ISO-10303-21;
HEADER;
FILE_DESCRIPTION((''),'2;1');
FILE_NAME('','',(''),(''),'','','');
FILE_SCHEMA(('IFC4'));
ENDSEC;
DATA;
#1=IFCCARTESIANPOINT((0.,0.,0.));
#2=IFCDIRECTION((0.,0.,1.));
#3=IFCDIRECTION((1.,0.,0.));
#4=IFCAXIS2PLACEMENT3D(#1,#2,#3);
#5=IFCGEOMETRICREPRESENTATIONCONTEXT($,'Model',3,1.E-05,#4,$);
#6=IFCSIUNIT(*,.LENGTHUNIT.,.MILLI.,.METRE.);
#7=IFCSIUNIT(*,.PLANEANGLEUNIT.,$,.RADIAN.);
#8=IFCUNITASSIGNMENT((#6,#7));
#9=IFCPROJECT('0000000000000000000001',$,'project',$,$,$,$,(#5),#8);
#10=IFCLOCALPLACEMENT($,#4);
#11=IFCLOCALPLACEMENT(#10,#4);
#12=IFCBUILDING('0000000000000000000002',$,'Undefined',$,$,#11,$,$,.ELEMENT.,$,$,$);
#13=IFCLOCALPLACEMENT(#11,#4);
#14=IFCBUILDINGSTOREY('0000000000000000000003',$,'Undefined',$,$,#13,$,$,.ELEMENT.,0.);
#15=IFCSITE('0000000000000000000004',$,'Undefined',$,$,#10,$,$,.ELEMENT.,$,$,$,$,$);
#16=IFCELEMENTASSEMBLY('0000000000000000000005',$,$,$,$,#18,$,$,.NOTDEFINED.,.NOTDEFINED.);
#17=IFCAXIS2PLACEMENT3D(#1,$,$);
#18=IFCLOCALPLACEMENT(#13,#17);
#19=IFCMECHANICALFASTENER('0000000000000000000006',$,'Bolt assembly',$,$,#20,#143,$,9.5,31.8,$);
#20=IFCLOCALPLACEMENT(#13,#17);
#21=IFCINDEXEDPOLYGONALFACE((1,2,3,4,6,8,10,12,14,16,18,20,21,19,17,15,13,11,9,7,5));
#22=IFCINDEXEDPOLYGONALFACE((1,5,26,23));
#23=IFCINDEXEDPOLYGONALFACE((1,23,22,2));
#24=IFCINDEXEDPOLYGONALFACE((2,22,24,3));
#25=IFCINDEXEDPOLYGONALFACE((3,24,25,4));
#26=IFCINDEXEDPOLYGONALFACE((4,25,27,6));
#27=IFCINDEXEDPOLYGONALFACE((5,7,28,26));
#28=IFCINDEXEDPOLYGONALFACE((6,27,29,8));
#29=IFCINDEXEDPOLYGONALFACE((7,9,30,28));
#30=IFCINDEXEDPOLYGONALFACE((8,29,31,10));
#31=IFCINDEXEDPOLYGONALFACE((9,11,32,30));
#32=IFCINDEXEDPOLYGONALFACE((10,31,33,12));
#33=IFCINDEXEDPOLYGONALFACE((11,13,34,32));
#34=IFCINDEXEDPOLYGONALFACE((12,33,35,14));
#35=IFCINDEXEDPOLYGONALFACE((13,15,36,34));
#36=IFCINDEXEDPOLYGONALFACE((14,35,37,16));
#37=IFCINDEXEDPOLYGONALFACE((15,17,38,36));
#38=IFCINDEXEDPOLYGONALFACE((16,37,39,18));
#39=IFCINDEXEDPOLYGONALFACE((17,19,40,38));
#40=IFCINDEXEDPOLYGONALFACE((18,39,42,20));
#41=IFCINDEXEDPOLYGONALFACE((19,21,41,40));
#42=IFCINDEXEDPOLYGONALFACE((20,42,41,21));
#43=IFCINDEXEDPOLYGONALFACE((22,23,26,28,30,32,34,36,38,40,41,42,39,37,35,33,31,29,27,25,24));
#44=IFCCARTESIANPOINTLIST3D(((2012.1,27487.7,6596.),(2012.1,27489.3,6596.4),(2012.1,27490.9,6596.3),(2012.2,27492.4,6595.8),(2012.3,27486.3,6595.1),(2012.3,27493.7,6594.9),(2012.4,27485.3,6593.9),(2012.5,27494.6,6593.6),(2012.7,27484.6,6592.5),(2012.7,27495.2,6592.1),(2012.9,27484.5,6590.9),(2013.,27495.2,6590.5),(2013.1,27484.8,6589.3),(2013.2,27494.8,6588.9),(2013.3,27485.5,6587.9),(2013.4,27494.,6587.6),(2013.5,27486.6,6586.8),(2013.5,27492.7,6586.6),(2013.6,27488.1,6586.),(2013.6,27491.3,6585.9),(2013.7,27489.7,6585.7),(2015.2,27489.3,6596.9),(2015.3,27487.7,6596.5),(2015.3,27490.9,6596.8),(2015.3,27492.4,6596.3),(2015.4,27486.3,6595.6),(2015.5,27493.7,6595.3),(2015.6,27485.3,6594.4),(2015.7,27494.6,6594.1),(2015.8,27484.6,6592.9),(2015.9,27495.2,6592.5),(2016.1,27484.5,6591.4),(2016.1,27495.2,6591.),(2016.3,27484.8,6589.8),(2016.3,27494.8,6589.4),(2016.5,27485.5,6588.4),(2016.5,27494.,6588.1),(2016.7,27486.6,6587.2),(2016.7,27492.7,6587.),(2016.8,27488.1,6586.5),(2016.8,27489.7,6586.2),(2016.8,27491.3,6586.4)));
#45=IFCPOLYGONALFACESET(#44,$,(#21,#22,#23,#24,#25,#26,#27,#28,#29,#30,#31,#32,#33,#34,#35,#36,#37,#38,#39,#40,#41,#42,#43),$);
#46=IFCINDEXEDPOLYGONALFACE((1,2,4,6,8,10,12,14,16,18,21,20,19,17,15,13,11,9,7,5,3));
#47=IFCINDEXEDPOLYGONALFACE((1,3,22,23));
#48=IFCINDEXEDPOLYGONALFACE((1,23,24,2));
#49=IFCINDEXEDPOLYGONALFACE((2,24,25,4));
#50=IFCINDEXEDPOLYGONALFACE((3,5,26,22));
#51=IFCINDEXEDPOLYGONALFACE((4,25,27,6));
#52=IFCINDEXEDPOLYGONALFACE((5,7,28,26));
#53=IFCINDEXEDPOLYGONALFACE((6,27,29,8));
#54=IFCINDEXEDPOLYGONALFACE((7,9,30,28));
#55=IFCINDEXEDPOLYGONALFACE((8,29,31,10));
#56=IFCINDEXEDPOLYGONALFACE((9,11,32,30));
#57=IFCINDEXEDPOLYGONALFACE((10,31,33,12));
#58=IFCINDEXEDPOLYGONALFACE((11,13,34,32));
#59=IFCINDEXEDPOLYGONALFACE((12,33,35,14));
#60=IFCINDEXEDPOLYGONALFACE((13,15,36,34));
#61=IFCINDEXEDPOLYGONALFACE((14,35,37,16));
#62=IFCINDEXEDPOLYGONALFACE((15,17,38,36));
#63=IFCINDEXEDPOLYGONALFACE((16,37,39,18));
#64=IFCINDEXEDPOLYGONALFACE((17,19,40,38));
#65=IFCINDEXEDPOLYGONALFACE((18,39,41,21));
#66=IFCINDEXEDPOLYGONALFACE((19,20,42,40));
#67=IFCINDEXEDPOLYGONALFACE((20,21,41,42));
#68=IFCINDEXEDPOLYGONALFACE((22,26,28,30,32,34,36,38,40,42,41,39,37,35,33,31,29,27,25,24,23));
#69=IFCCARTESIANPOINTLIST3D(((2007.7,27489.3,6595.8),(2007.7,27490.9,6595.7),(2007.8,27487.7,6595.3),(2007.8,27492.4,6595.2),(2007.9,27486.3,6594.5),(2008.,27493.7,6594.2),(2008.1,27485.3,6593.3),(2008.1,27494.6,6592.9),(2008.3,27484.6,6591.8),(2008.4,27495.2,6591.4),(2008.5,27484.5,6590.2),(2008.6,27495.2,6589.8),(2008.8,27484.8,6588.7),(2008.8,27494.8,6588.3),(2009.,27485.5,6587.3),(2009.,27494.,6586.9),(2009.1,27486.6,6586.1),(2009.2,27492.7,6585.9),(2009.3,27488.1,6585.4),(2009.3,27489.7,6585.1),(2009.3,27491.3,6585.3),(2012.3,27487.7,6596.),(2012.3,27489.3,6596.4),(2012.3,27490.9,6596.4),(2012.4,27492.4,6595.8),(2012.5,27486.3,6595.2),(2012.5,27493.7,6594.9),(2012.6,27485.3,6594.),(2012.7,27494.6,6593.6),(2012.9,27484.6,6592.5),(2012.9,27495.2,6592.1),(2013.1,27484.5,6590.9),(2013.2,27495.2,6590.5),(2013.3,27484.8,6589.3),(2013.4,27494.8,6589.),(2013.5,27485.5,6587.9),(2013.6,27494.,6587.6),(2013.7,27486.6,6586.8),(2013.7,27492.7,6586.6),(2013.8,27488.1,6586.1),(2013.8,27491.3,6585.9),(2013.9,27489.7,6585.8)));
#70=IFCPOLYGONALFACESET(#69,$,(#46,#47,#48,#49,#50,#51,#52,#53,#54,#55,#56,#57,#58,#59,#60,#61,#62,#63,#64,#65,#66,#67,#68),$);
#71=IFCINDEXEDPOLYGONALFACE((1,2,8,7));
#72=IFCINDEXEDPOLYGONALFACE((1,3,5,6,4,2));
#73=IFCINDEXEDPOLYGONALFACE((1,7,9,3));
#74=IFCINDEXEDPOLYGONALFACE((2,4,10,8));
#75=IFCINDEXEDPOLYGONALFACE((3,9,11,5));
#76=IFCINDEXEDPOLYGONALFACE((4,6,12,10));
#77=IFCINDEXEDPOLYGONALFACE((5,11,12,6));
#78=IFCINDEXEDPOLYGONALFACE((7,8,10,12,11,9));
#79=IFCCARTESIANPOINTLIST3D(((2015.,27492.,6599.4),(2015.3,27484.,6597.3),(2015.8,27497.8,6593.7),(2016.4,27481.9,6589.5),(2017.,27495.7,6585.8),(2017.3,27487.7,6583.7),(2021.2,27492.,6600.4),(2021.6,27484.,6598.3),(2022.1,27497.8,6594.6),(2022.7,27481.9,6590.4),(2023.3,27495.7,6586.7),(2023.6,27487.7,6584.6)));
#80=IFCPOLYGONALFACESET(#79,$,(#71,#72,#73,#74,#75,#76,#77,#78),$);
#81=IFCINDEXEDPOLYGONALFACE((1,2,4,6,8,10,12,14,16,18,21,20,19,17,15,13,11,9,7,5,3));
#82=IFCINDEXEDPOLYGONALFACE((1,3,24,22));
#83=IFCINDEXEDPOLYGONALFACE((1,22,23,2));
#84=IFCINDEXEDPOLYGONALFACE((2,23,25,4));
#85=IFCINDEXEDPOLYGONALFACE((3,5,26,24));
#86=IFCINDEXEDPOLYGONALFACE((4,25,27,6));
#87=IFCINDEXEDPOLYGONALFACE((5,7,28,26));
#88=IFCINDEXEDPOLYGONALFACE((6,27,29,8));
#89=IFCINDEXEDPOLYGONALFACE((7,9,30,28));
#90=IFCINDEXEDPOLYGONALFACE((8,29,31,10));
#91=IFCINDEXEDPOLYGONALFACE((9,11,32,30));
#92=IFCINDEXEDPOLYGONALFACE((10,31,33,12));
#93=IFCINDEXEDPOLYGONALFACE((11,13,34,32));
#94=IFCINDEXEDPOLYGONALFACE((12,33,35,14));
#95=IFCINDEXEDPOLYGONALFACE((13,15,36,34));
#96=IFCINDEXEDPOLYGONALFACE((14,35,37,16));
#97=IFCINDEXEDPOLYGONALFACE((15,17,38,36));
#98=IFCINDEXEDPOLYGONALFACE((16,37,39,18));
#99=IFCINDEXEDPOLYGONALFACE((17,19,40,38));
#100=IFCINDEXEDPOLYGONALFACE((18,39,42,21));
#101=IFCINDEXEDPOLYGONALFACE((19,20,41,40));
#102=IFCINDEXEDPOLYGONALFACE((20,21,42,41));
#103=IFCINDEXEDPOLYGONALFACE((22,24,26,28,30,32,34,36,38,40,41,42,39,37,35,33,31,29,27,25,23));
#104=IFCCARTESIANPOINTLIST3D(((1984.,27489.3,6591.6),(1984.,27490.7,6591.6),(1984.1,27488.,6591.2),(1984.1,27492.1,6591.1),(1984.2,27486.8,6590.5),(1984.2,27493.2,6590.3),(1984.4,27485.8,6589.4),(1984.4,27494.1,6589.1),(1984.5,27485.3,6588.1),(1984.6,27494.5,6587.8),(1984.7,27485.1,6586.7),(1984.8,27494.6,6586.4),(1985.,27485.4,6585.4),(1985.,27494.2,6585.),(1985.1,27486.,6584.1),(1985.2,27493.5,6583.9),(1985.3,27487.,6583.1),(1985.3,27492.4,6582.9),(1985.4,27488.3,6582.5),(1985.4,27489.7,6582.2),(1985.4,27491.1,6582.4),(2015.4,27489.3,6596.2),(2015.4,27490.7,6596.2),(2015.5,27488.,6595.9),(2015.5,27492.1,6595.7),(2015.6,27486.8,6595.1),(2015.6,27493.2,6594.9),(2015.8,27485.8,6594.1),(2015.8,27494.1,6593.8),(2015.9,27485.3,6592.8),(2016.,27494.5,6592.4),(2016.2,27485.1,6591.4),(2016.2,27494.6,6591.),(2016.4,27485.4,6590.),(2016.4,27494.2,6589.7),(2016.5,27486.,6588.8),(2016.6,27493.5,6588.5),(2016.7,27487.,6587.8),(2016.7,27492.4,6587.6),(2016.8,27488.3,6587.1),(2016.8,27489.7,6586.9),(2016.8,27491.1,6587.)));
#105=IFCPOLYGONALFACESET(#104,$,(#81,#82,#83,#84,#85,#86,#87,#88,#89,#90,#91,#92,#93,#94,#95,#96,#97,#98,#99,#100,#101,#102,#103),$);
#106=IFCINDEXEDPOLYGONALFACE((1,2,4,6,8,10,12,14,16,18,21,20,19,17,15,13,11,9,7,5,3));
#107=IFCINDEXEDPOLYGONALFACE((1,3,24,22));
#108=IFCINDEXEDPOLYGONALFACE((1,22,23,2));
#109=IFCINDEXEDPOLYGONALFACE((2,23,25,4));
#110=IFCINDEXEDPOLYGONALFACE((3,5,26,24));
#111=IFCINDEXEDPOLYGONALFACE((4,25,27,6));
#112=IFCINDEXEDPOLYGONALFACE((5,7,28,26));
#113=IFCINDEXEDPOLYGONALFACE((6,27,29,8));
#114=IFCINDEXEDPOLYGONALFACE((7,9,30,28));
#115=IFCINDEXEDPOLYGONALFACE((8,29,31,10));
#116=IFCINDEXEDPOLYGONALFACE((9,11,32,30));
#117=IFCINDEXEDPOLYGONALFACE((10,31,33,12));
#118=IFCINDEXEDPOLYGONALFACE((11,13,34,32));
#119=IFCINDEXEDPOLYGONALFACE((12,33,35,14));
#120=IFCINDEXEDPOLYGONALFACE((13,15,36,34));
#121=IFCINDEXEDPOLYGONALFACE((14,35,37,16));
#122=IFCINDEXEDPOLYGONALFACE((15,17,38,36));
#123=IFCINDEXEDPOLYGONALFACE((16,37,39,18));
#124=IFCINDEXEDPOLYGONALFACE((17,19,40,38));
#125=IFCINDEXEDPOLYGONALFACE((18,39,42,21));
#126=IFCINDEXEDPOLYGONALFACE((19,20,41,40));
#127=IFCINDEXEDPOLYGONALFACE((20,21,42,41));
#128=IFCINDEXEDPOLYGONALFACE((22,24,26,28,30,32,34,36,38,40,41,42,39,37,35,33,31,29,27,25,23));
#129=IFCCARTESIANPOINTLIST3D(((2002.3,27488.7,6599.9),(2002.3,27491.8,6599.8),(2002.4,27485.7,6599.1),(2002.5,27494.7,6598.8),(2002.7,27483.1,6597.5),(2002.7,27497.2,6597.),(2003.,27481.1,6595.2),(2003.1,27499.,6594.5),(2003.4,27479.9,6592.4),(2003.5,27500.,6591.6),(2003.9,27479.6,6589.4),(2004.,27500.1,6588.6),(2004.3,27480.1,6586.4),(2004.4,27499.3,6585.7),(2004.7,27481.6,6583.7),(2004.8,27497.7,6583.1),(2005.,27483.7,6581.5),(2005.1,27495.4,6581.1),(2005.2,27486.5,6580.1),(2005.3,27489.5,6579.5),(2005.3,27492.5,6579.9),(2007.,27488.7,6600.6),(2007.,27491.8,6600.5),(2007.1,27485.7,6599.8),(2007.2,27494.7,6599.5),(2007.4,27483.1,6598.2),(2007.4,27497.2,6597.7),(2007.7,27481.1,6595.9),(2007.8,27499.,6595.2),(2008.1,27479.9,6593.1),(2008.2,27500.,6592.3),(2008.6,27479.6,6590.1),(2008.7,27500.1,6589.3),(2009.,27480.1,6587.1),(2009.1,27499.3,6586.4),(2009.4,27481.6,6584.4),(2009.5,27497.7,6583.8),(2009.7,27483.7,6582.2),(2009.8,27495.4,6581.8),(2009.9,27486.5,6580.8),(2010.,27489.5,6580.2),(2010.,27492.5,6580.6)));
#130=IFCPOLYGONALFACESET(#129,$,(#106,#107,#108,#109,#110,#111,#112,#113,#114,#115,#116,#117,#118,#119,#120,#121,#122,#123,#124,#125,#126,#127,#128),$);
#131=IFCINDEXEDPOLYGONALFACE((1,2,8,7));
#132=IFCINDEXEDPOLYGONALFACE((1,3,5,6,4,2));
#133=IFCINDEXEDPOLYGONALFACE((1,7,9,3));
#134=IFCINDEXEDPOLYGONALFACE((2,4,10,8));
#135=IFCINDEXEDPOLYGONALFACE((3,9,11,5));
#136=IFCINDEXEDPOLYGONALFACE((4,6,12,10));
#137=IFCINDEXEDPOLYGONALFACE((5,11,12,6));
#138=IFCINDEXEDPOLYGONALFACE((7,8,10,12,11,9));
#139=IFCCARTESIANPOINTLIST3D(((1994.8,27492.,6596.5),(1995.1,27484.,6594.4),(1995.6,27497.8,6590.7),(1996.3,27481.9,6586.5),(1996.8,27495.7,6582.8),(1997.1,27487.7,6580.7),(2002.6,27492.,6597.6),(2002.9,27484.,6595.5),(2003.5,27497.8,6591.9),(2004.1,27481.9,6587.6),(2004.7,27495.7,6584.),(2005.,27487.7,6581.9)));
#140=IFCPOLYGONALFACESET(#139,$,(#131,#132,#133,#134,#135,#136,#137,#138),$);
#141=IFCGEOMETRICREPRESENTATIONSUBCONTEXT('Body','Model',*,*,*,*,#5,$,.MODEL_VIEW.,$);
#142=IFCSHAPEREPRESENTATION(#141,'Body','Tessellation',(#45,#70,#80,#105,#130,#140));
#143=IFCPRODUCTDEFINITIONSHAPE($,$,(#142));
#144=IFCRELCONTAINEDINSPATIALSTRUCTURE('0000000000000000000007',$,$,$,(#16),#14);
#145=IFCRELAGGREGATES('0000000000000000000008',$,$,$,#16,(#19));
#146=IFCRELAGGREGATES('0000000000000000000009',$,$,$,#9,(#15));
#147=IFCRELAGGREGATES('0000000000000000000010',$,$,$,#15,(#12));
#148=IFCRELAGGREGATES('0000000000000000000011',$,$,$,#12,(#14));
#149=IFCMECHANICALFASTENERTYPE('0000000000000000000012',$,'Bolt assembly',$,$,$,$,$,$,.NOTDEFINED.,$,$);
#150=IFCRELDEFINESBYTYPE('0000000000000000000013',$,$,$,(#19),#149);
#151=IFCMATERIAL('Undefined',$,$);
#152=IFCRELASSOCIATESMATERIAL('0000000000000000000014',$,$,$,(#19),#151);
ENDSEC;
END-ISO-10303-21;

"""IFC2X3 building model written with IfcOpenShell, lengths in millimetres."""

from ifc_helpers import new_model, si_unit, frame, origin_with_axes, origin_2d_with_axis, place, context, subcontext, project, spatial, polyline, circle, outline, extrude, source, transform, mapped, material, type_object, element, aggregate, save


model = new_model("IFC2X3")

# Units and contexts
model_context = context("Model", 3, precision=1e-05, world=origin_with_axes())
body_context = subcontext(model_context, "Body", "Model", "MODEL_VIEW")
ifc_project = project(units=[si_unit("LENGTHUNIT", "METRE", prefix="MILLI"), si_unit("PLANEANGLEUNIT", "RADIAN")], contexts=[model_context])

# Site, building, storey
site_placement = place(None, origin_with_axes())
site = spatial("IfcSite", under=ifc_project, at=site_placement, Name="Undefined", CompositionType="ELEMENT")
building_placement = place(site_placement, origin_with_axes())
building = spatial("IfcBuilding", under=site, at=building_placement, Name="Undefined", CompositionType="ELEMENT")
storey_placement = place(building_placement, origin_with_axes())
storey = spatial("IfcBuildingStorey", under=building, at=storey_placement, Name="Undefined", CompositionType="ELEMENT", Elevation=0.0)

# Element assembly
assembly_1_placement = place(storey_placement, origin_with_axes())
assembly_1 = element("IfcElementAssembly", 1, at=assembly_1_placement, inside=storey, AssemblyPlace="NOTDEFINED", PredefinedType="NOTDEFINED")

# Shared definitions
ifc_material_1 = material(Name="Undefined")
mechanical_fastener_type = type_object("IfcMechanicalFastenerType", Name="Bolt assembly")

# Mechanical fastener
shared_shape_1 = source(origin_with_axes(), body_context, "Body", "SweptSolid", [
    extrude(circle(Radius=5.4, at=origin_2d_with_axis()), frame((0.0, -3.1, 0.0), z_axis=(0.0, 1.0, 0.0), x_axis=(1.0, 0.0, 0.0)), (0.0, 0.0, 1.0), 3.2),
    extrude(circle(Radius=5.4, at=origin_2d_with_axis()), frame((0.0, -0.1, 0.0), z_axis=(0.0, 1.0, 0.0), x_axis=(1.0, 0.0, 0.0)), (0.0, 0.0, 1.0), 4.6),
    extrude(outline(polyline([(7.1, -4.1), (7.1, 4.1), (0.0, 8.2), (-7.1, 4.1), (-7.1, -4.1), (0.0, -8.2), (7.1, -4.1)])), frame((0.0, -9.6, 0.0), z_axis=(0.0, 1.0, 0.0), x_axis=(1.0, 0.0, 0.0)), (0.0, 0.0, 1.0), 6.3),
    extrude(circle(Radius=4.8, at=origin_2d_with_axis()), frame((0.0, -3.2, 0.0), z_axis=(0.0, 1.0, 0.0), x_axis=(1.0, 0.0, 0.0)), (0.0, 0.0, 1.0), 31.8),
    extrude(circle(Radius=10.3, at=origin_2d_with_axis()), frame((0.0, 4.5, 0.0), z_axis=(0.0, 1.0, 0.0), x_axis=(1.0, 0.0, 0.0)), (0.0, 0.0, 1.0), 4.8),
    extrude(outline(polyline([(7.1, -4.1), (7.1, 4.1), (0.0, 8.2), (-7.1, 4.1), (-7.1, -4.1), (0.0, -8.2), (7.1, -4.1)])), frame((0.0, 9.3, 0.0), z_axis=(0.0, 1.0, 0.0), x_axis=(1.0, 0.0, 0.0)), (0.0, 0.0, 1.0), 7.9),
])
mechanical_fastener_1_placement = place(assembly_1_placement, frame((2013.0, 27489.9, 6591.1), z_axis=(-0.103381, -0.707107, 0.699509), x_axis=(-0.103381, 0.707107, 0.699509)))
mechanical_fastener_1 = element("IfcMechanicalFastener", 2, at=mechanical_fastener_1_placement, type_object=mechanical_fastener_type, material=ifc_material_1, Name="Bolt assembly", NominalDiameter=9.5, NominalLength=31.8, context=body_context, shape_type="MappedRepresentation", body=[
    mapped(shared_shape_1, transform((0.0, 0.0, 0.0))),
])
aggregate(assembly_1, [mechanical_fastener_1])

save(model, "model.ifc")
